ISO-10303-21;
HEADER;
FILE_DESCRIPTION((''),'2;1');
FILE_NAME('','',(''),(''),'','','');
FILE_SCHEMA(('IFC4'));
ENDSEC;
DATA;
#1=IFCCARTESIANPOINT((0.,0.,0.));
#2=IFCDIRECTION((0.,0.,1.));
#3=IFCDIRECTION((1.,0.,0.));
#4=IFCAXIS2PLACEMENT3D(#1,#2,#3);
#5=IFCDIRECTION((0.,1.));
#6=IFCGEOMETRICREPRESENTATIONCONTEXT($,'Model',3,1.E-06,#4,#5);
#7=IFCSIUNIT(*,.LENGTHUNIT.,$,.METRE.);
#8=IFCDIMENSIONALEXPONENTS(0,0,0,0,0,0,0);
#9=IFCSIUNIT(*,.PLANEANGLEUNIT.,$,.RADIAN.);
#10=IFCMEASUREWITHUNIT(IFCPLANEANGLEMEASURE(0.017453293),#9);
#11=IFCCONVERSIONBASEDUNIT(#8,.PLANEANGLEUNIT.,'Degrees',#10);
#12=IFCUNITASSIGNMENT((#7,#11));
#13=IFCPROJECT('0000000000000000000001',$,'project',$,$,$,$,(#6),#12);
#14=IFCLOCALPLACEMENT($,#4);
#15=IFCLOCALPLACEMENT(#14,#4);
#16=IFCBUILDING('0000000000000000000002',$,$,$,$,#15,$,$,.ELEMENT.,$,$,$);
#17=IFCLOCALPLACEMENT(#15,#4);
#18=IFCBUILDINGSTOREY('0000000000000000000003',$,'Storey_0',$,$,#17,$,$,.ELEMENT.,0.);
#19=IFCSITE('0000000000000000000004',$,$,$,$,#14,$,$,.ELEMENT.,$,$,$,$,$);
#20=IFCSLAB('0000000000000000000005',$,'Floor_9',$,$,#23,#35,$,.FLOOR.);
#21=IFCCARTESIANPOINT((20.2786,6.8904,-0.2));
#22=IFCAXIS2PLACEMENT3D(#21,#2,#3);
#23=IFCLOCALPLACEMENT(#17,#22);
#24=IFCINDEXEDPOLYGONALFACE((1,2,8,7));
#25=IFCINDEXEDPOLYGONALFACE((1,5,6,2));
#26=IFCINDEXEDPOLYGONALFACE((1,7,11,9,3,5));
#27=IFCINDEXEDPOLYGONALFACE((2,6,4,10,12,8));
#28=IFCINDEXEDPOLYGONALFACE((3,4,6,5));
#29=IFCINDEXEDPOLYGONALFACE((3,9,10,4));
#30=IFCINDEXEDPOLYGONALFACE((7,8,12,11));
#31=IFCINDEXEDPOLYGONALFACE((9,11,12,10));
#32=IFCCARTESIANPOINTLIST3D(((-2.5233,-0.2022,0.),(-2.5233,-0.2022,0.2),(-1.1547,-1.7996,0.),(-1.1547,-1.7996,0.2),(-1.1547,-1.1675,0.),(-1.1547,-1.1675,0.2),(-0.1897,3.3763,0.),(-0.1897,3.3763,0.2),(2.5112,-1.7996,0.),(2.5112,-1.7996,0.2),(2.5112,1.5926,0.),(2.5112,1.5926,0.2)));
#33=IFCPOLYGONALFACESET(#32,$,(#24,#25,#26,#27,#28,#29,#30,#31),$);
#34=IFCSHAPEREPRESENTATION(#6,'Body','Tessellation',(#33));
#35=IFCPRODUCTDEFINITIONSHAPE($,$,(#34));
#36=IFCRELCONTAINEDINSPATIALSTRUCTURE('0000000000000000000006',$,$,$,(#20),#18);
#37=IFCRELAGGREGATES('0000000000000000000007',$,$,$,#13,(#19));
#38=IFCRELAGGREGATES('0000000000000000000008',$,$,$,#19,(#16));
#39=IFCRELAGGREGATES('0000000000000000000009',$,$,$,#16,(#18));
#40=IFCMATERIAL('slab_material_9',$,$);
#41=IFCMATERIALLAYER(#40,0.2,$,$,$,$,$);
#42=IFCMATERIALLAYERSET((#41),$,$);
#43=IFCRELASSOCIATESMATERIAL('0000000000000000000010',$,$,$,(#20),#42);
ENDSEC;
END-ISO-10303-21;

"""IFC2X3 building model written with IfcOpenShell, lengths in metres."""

from ifc_helpers import new_model, entity, si_unit, converted_unit, direction, frame, origin_with_axes, place, context, project, spatial, polyline, outline, extrude, material, layer, layer_set, layer_usage, element, save


model = new_model("IFC2X3")

# Units and contexts
model_context = context("Model", 3, precision=1e-06, world=origin_with_axes(), true_north=direction((0.0, 1.0)))
ifc_project = project(units=[si_unit("LENGTHUNIT", "METRE"), converted_unit("PLANEANGLEUNIT", "Degrees", entity("IfcPlaneAngleMeasure", 0.017453293), si_unit("PLANEANGLEUNIT", "RADIAN"), dimensions=[0, 0, 0, 0, 0, 0, 0])], contexts=[model_context])

# Site, building, storey
site_placement = place(None, origin_with_axes())
site = spatial("IfcSite", under=ifc_project, at=site_placement, CompositionType="ELEMENT")
building_placement = place(site_placement, origin_with_axes())
building = spatial("IfcBuilding", under=site, at=building_placement, CompositionType="ELEMENT")
storey_placement = place(building_placement, origin_with_axes())
storey = spatial("IfcBuildingStorey", under=building, at=storey_placement, Name="Storey_0", CompositionType="ELEMENT", Elevation=0.0)

# Slab
ifc_material_1 = material(Name="slab_material_9")
ifc_layer_1 = layer(ifc_material_1, 0.2)
ifc_layer_set_1 = layer_set([ifc_layer_1])
ifc_layer_usage_1 = layer_usage(ifc_layer_set_1, "AXIS3", "POSITIVE", 0.0)
slab_placement = place(storey_placement, frame((20.2786, 6.8904, -0.2), z_axis=(0.0, 0.0, 1.0), x_axis=(1.0, 0.0, 0.0)))
element("IfcSlab", 1, at=slab_placement, inside=storey, material=ifc_layer_usage_1, Name="Floor_9", PredefinedType="FLOOR", context=model_context, shape_type="SweptSolid", body=[
    extrude(outline(polyline([(-0.1897, 3.3763), (-2.5233, -0.2022), (-1.1547, -1.1675), (-1.1547, -1.7996), (2.5112, -1.7996), (2.5112, 1.5926), (-0.1897, 3.3763)])), origin_with_axes(), (0.0, 0.0, 1.0), 0.2),
])

save(model, "model.ifc")
